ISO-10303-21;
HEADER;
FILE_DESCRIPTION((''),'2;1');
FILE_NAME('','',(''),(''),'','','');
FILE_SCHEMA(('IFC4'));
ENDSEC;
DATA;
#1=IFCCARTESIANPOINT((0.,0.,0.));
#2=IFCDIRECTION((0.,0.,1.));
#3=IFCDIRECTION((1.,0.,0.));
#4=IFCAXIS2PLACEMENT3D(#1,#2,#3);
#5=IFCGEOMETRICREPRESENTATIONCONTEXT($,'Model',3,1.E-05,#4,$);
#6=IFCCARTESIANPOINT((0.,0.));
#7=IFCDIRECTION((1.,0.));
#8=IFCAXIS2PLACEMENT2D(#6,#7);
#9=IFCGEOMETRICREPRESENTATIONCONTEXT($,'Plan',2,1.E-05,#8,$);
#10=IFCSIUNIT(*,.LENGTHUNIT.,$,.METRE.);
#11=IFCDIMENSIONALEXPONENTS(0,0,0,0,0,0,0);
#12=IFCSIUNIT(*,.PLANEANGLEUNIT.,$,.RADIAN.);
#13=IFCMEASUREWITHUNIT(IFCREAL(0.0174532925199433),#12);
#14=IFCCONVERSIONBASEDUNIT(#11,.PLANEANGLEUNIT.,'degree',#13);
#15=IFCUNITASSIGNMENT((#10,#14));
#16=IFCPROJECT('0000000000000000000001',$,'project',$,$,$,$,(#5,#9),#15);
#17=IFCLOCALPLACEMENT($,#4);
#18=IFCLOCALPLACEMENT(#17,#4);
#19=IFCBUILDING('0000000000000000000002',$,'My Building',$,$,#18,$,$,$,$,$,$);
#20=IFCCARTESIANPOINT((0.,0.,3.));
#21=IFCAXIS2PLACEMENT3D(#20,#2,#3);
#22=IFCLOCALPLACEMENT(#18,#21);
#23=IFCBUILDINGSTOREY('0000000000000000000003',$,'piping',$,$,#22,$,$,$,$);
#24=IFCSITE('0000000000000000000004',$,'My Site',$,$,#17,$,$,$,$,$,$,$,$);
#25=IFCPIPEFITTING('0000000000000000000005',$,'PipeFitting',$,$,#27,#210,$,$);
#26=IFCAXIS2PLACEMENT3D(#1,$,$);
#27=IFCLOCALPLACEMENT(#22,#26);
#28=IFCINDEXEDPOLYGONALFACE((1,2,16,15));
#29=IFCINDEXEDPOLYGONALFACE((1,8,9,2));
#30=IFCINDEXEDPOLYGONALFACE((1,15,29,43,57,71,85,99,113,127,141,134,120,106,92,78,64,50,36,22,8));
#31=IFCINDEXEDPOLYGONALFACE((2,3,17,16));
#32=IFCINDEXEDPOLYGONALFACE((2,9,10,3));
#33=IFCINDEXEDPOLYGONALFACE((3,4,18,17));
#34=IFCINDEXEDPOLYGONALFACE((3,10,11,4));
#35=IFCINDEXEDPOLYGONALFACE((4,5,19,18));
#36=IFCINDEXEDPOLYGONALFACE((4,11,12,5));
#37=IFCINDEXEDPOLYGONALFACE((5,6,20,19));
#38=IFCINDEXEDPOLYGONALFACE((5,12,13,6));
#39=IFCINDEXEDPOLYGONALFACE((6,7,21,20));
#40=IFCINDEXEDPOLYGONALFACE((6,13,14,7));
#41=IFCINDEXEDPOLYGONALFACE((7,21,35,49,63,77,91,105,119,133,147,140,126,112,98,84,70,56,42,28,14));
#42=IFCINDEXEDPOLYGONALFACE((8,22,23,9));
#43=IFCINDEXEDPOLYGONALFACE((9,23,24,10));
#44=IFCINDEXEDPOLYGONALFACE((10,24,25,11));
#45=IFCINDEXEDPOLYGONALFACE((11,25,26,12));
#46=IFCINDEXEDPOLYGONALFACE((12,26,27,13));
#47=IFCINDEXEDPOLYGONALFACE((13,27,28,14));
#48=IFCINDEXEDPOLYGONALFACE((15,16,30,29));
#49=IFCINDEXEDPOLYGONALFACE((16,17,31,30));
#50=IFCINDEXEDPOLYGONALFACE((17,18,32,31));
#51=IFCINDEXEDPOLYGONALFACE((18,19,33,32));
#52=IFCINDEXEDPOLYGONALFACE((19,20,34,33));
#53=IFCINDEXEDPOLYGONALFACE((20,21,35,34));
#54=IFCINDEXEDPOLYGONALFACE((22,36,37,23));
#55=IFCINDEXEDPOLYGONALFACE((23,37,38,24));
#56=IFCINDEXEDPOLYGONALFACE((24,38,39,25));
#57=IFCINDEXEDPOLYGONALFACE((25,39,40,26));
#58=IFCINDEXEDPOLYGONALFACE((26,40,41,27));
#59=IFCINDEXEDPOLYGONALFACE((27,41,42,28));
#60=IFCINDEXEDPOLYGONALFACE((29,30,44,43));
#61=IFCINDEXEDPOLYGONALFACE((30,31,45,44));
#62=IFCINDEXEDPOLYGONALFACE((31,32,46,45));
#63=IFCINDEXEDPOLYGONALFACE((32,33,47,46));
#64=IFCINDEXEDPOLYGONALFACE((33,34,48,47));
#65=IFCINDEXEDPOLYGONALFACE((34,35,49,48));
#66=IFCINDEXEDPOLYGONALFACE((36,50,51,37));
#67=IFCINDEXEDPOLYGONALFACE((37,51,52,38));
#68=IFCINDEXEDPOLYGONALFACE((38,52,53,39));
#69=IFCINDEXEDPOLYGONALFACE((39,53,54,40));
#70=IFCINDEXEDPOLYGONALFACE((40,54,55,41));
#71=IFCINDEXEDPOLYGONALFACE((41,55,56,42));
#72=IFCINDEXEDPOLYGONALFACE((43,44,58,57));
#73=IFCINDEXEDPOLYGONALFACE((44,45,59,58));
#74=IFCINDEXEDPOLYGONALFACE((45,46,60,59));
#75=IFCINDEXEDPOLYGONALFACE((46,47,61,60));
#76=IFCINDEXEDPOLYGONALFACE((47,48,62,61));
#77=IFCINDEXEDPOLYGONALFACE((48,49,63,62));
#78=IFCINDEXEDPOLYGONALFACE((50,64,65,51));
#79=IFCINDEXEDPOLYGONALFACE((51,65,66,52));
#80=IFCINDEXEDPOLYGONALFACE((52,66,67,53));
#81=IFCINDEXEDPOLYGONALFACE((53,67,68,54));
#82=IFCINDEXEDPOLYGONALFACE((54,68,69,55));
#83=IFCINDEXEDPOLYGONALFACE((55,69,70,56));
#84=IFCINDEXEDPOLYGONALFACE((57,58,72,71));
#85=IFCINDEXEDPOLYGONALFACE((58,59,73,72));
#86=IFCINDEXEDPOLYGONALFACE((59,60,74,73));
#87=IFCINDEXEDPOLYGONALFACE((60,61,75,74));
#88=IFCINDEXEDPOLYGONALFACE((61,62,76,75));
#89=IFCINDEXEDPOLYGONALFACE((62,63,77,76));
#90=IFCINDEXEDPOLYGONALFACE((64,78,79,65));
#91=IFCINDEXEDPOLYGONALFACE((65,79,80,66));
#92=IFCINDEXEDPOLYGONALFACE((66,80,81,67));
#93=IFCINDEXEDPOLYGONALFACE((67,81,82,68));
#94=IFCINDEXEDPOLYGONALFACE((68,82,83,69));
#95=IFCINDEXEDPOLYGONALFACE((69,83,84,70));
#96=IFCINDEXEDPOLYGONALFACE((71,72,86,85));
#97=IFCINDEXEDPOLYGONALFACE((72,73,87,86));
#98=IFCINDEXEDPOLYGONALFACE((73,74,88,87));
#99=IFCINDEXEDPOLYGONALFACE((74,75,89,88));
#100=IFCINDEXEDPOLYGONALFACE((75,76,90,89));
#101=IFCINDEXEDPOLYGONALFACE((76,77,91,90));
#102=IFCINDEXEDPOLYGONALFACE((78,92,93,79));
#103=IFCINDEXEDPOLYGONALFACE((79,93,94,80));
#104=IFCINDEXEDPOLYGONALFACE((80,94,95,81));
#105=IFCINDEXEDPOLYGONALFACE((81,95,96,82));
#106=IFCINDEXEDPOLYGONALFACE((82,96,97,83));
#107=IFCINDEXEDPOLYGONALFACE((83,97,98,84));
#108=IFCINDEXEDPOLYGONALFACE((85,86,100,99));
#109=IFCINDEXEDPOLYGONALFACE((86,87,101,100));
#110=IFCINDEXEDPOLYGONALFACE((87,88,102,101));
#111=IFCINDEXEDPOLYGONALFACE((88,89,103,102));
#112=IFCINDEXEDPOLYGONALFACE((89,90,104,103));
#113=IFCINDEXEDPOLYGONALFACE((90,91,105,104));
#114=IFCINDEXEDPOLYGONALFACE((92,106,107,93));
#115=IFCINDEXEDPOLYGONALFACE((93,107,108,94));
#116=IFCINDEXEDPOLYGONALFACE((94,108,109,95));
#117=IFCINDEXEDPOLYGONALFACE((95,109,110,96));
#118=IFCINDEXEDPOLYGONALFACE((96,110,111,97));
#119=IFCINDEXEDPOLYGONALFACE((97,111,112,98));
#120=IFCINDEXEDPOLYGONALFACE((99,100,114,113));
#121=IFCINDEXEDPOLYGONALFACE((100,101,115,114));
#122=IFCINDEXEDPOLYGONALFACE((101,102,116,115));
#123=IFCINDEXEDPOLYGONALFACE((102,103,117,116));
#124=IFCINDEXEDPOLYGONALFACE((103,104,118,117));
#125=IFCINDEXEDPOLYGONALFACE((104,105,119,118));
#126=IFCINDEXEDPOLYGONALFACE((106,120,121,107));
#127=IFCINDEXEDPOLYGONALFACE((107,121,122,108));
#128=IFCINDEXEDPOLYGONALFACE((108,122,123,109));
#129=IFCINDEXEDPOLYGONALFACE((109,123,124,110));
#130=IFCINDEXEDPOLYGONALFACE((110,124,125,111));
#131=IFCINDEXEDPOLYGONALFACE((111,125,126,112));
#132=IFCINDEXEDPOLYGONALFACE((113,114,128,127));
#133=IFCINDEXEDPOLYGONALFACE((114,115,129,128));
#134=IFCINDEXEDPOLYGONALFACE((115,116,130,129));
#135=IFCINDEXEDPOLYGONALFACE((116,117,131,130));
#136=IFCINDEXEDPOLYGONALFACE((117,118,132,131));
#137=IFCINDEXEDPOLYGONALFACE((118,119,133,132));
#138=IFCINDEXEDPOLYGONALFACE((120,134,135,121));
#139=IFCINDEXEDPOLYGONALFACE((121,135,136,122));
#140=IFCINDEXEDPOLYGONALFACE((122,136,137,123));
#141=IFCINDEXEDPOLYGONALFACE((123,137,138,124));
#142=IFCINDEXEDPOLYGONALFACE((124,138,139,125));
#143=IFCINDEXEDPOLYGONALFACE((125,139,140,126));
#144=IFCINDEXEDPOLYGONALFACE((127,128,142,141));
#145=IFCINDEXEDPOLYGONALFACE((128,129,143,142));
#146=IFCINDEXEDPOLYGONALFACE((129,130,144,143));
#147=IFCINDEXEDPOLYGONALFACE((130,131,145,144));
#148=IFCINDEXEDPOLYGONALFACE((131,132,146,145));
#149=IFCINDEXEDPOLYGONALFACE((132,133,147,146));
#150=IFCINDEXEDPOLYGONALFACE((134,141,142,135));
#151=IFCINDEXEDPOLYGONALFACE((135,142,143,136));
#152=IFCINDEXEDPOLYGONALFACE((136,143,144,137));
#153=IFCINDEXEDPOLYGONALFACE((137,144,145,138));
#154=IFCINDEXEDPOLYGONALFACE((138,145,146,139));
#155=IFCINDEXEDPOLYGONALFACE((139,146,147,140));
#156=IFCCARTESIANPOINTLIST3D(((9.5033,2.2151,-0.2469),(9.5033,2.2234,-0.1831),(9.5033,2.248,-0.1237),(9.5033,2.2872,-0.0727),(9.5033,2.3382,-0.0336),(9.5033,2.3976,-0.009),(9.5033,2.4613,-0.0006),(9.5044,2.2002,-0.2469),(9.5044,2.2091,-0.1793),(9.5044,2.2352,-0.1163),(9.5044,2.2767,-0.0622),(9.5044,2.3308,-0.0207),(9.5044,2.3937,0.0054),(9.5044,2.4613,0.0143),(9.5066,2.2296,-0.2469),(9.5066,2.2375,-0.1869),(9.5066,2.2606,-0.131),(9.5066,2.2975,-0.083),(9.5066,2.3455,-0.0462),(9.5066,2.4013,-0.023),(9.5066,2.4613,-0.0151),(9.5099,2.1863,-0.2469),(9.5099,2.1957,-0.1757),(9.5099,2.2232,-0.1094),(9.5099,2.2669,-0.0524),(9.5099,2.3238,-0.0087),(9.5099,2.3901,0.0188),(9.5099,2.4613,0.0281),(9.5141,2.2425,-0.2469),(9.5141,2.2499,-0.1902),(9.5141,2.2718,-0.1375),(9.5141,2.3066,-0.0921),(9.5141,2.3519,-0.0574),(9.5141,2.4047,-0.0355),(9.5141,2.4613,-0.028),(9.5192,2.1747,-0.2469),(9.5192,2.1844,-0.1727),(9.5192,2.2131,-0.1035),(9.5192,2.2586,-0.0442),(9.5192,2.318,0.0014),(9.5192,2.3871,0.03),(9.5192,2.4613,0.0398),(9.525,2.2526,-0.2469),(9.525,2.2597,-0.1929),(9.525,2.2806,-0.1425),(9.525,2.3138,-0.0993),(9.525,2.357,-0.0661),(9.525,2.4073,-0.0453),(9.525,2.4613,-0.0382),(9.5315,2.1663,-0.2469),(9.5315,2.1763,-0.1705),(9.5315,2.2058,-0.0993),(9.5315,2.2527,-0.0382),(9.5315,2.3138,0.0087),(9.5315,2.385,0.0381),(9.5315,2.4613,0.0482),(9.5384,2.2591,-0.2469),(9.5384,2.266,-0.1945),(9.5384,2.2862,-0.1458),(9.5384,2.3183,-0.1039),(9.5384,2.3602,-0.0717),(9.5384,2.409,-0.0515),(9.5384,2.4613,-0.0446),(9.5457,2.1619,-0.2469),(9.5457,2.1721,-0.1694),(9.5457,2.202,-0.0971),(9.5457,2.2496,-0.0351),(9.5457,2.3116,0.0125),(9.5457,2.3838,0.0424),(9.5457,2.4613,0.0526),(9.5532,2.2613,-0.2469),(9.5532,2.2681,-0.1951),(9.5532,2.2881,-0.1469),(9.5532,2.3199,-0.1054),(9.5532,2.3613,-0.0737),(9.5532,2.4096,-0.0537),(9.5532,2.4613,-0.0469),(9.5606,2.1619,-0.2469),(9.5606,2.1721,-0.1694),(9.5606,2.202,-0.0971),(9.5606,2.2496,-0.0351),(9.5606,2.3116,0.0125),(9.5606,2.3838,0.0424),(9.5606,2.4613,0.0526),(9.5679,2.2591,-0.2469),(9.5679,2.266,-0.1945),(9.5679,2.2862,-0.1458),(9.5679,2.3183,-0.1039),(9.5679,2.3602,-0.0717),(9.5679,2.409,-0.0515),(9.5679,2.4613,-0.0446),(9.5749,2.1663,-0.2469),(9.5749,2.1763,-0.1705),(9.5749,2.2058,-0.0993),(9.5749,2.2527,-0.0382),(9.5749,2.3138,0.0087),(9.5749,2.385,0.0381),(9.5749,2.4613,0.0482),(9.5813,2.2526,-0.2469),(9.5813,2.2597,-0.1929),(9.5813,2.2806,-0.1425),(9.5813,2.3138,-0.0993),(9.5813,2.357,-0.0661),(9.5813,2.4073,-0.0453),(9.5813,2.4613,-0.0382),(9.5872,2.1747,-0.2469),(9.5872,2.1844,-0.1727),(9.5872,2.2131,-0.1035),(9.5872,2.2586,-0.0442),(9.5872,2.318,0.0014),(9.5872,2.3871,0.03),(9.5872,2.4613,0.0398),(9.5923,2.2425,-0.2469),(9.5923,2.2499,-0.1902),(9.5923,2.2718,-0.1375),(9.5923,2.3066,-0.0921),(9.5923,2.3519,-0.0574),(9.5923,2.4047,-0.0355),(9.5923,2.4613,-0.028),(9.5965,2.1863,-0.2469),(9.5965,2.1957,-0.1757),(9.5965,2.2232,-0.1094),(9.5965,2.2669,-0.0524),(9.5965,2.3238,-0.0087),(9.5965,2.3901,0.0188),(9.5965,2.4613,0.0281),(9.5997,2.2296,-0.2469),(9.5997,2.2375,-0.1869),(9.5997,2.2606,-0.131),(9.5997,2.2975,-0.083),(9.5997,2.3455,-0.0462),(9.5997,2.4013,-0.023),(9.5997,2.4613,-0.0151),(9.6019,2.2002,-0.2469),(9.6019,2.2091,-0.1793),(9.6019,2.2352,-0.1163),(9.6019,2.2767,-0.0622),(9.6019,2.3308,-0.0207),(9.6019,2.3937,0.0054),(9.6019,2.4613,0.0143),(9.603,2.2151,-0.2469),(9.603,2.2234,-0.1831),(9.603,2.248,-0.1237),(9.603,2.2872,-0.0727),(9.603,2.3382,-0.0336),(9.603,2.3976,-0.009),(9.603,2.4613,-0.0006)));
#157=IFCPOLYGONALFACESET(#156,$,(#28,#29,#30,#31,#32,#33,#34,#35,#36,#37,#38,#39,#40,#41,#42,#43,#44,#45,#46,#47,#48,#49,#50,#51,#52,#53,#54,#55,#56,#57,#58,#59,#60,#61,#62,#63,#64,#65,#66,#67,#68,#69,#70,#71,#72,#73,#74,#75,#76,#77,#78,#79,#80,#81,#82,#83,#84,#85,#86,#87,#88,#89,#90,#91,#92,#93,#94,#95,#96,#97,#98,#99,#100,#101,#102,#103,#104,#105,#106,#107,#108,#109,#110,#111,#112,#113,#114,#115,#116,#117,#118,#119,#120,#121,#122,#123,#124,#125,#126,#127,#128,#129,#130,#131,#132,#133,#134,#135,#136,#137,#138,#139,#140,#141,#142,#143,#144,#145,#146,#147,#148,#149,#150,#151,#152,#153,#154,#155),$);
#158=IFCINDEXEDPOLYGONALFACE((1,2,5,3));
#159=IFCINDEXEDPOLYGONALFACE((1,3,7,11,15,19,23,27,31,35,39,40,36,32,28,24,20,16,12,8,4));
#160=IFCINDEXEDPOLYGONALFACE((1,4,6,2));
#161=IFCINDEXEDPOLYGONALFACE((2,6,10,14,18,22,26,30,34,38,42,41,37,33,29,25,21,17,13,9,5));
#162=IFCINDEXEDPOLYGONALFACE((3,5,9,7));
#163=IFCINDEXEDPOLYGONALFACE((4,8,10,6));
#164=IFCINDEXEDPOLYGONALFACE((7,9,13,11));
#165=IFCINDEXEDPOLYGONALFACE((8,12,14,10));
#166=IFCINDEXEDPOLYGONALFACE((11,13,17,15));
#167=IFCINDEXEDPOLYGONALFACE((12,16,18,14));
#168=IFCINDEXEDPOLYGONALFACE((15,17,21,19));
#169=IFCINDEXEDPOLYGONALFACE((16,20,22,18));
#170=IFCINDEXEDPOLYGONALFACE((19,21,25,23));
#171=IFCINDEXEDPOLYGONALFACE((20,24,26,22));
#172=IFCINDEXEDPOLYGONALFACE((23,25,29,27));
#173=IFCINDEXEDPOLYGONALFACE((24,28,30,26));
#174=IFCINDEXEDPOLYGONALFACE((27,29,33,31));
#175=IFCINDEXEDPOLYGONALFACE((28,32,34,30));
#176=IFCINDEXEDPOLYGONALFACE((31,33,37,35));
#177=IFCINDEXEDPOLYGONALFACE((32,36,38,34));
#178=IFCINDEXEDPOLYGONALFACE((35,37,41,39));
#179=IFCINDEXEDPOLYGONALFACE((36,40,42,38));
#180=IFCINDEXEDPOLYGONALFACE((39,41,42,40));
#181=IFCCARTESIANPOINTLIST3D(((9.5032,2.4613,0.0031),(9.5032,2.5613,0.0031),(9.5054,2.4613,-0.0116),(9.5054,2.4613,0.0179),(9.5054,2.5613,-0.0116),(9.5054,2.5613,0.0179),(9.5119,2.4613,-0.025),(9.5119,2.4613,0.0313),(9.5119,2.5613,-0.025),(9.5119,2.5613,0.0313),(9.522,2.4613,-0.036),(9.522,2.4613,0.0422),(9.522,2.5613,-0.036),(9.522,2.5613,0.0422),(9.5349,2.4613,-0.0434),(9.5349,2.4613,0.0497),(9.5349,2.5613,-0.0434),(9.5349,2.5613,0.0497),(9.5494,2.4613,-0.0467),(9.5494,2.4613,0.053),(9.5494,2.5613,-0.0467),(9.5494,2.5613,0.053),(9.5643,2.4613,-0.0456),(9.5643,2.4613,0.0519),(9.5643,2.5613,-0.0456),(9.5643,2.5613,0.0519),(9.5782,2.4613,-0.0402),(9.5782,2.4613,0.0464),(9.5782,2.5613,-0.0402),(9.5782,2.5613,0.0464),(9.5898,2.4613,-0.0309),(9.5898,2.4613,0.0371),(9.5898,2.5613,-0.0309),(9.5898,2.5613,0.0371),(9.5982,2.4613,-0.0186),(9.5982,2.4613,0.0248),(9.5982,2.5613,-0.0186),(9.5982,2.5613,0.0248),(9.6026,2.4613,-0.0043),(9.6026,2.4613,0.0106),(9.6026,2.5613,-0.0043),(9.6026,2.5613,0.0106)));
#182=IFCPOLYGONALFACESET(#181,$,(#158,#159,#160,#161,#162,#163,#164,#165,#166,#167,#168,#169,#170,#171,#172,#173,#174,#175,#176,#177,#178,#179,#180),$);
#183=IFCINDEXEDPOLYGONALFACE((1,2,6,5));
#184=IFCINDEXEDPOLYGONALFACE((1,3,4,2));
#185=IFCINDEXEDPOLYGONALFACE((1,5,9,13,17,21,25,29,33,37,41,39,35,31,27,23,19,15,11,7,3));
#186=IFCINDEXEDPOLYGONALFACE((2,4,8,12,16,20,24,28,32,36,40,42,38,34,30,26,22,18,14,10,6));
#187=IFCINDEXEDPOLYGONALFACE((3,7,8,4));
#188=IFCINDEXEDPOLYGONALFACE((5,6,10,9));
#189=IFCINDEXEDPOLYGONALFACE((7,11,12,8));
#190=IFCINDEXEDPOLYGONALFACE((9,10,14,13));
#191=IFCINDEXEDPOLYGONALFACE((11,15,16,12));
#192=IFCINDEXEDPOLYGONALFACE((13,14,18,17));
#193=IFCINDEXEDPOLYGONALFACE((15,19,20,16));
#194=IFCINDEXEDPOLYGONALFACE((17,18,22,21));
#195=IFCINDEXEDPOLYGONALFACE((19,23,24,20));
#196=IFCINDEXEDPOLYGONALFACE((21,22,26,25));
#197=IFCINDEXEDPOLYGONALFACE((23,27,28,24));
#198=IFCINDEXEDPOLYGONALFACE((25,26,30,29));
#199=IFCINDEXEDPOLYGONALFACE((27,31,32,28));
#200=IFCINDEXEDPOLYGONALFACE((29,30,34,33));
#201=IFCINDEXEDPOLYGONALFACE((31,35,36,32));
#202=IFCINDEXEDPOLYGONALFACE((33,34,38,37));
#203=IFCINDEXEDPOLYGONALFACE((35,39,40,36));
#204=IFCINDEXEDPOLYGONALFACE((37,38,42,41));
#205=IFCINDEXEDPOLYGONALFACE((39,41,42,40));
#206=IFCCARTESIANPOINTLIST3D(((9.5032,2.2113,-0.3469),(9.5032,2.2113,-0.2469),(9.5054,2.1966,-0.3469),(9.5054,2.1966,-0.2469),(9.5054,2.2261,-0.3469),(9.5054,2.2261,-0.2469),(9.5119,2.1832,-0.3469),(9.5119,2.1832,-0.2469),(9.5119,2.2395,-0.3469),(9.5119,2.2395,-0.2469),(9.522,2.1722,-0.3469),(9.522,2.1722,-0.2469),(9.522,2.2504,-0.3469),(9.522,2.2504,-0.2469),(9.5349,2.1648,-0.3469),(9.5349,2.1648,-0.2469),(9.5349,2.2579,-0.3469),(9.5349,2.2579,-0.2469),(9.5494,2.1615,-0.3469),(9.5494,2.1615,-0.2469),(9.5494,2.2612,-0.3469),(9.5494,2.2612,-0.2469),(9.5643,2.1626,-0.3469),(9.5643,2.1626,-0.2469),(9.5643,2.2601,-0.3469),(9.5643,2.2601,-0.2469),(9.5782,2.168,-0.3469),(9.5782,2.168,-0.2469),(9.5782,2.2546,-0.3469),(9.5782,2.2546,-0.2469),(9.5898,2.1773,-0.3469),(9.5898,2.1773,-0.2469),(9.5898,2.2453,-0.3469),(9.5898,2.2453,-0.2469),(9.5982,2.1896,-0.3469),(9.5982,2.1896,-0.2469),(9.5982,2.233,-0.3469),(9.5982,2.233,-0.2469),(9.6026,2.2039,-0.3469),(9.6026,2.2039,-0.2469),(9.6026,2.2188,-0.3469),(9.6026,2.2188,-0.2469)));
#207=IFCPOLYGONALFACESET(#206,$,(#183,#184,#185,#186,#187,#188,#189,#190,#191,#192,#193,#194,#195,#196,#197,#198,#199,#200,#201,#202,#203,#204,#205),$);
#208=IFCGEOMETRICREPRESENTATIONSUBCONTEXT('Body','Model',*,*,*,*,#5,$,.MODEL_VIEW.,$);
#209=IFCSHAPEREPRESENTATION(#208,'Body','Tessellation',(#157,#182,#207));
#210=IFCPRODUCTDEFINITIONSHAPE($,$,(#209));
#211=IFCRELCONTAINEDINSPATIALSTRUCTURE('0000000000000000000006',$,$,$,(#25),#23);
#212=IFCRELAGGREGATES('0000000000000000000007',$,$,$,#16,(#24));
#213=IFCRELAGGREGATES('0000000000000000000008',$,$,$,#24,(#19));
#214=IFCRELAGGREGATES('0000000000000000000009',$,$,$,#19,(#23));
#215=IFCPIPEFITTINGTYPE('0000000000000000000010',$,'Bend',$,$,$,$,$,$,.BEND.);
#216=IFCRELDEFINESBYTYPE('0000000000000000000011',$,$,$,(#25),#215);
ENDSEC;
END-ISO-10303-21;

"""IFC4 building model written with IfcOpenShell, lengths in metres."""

from ifc_helpers import new_model, entity, si_unit, converted_unit, frame, origin_with_axes, origin_2d_with_axis, place, context, subcontext, project, spatial, circle, extrude, source, transform, mapped, type_object, type_shapes, element, save


model = new_model("IFC4")

# Units and contexts
model_context = context("Model", 3, precision=1e-05, world=origin_with_axes())
plan_context = context("Plan", 2, precision=1e-05, world=origin_2d_with_axis())
body_context = subcontext(model_context, "Body", "Model", "MODEL_VIEW")
ifc_project = project(units=[si_unit("LENGTHUNIT", "METRE"), converted_unit("PLANEANGLEUNIT", "degree", entity("IfcReal", 0.0174532925199433), si_unit("PLANEANGLEUNIT", "RADIAN"), dimensions=[0, 0, 0, 0, 0, 0, 0])], contexts=[model_context, plan_context])

# Site, building, storey
site_placement = place(None, origin_with_axes())
site = spatial("IfcSite", under=ifc_project, at=site_placement, Name="My Site")
building_placement = place(site_placement, origin_with_axes())
building = spatial("IfcBuilding", under=site, at=building_placement, Name="My Building")
storey_placement = place(building_placement, frame((0.0, 0.0, 3.0), z_axis=(0.0, 0.0, 1.0), x_axis=(1.0, 0.0, 0.0)))
storey = spatial("IfcBuildingStorey", under=building, at=storey_placement, Name="piping")

# Pipe fitting
pipe_fitting_type = type_object("IfcPipeFittingType", Name="Bend", PredefinedType="BEND")
shared_shape = source(origin_with_axes(), body_context, "Body", "SolidModel", [
    entity("IfcSweptDiskSolid", entity("IfcIndexedPolyCurve", entity("IfcCartesianPointList3D", [[0.0, 0.0, -0.1], [0.0, -0.0732, -0.2768], [0.0, -0.25, -0.35]]), [entity("IfcArcIndex", [1, 2, 3])]), 0.05),
    extrude(circle(Radius=0.05), origin_with_axes(), (0.0, 0.0, -1.0), 0.1),
    extrude(circle(Radius=0.05), frame((0.0, -0.25, -0.35), z_axis=(0.0, -1.0, 0.0), x_axis=(1.0, 0.0, 0.0)), (0.0, 0.0, 1.0), 0.1),
])
type_shapes(pipe_fitting_type, [shared_shape])
for number, where, z_axis, x_axis, name in (
    (1, (9.5532, 2.5613, 0.0031), (0.0, 1.0, 0.0), (-1.0, 0.0, 0.0), "PipeFitting"),
):
    element("IfcPipeFitting", number, at=place(storey_placement, frame(where, z_axis=z_axis, x_axis=x_axis)), inside=storey, type_object=pipe_fitting_type, Name=name, context=body_context, shape_type="MappedRepresentation", body=[
        mapped(shared_shape, transform((0.0, 0.0, 0.0), x_axis=(1.0, 0.0, 0.0), y_axis=(0.0, 1.0, 0.0), z_axis=(0.0, 0.0, 1.0), scale=1.0)),
    ])

save(model, "model.ifc")
